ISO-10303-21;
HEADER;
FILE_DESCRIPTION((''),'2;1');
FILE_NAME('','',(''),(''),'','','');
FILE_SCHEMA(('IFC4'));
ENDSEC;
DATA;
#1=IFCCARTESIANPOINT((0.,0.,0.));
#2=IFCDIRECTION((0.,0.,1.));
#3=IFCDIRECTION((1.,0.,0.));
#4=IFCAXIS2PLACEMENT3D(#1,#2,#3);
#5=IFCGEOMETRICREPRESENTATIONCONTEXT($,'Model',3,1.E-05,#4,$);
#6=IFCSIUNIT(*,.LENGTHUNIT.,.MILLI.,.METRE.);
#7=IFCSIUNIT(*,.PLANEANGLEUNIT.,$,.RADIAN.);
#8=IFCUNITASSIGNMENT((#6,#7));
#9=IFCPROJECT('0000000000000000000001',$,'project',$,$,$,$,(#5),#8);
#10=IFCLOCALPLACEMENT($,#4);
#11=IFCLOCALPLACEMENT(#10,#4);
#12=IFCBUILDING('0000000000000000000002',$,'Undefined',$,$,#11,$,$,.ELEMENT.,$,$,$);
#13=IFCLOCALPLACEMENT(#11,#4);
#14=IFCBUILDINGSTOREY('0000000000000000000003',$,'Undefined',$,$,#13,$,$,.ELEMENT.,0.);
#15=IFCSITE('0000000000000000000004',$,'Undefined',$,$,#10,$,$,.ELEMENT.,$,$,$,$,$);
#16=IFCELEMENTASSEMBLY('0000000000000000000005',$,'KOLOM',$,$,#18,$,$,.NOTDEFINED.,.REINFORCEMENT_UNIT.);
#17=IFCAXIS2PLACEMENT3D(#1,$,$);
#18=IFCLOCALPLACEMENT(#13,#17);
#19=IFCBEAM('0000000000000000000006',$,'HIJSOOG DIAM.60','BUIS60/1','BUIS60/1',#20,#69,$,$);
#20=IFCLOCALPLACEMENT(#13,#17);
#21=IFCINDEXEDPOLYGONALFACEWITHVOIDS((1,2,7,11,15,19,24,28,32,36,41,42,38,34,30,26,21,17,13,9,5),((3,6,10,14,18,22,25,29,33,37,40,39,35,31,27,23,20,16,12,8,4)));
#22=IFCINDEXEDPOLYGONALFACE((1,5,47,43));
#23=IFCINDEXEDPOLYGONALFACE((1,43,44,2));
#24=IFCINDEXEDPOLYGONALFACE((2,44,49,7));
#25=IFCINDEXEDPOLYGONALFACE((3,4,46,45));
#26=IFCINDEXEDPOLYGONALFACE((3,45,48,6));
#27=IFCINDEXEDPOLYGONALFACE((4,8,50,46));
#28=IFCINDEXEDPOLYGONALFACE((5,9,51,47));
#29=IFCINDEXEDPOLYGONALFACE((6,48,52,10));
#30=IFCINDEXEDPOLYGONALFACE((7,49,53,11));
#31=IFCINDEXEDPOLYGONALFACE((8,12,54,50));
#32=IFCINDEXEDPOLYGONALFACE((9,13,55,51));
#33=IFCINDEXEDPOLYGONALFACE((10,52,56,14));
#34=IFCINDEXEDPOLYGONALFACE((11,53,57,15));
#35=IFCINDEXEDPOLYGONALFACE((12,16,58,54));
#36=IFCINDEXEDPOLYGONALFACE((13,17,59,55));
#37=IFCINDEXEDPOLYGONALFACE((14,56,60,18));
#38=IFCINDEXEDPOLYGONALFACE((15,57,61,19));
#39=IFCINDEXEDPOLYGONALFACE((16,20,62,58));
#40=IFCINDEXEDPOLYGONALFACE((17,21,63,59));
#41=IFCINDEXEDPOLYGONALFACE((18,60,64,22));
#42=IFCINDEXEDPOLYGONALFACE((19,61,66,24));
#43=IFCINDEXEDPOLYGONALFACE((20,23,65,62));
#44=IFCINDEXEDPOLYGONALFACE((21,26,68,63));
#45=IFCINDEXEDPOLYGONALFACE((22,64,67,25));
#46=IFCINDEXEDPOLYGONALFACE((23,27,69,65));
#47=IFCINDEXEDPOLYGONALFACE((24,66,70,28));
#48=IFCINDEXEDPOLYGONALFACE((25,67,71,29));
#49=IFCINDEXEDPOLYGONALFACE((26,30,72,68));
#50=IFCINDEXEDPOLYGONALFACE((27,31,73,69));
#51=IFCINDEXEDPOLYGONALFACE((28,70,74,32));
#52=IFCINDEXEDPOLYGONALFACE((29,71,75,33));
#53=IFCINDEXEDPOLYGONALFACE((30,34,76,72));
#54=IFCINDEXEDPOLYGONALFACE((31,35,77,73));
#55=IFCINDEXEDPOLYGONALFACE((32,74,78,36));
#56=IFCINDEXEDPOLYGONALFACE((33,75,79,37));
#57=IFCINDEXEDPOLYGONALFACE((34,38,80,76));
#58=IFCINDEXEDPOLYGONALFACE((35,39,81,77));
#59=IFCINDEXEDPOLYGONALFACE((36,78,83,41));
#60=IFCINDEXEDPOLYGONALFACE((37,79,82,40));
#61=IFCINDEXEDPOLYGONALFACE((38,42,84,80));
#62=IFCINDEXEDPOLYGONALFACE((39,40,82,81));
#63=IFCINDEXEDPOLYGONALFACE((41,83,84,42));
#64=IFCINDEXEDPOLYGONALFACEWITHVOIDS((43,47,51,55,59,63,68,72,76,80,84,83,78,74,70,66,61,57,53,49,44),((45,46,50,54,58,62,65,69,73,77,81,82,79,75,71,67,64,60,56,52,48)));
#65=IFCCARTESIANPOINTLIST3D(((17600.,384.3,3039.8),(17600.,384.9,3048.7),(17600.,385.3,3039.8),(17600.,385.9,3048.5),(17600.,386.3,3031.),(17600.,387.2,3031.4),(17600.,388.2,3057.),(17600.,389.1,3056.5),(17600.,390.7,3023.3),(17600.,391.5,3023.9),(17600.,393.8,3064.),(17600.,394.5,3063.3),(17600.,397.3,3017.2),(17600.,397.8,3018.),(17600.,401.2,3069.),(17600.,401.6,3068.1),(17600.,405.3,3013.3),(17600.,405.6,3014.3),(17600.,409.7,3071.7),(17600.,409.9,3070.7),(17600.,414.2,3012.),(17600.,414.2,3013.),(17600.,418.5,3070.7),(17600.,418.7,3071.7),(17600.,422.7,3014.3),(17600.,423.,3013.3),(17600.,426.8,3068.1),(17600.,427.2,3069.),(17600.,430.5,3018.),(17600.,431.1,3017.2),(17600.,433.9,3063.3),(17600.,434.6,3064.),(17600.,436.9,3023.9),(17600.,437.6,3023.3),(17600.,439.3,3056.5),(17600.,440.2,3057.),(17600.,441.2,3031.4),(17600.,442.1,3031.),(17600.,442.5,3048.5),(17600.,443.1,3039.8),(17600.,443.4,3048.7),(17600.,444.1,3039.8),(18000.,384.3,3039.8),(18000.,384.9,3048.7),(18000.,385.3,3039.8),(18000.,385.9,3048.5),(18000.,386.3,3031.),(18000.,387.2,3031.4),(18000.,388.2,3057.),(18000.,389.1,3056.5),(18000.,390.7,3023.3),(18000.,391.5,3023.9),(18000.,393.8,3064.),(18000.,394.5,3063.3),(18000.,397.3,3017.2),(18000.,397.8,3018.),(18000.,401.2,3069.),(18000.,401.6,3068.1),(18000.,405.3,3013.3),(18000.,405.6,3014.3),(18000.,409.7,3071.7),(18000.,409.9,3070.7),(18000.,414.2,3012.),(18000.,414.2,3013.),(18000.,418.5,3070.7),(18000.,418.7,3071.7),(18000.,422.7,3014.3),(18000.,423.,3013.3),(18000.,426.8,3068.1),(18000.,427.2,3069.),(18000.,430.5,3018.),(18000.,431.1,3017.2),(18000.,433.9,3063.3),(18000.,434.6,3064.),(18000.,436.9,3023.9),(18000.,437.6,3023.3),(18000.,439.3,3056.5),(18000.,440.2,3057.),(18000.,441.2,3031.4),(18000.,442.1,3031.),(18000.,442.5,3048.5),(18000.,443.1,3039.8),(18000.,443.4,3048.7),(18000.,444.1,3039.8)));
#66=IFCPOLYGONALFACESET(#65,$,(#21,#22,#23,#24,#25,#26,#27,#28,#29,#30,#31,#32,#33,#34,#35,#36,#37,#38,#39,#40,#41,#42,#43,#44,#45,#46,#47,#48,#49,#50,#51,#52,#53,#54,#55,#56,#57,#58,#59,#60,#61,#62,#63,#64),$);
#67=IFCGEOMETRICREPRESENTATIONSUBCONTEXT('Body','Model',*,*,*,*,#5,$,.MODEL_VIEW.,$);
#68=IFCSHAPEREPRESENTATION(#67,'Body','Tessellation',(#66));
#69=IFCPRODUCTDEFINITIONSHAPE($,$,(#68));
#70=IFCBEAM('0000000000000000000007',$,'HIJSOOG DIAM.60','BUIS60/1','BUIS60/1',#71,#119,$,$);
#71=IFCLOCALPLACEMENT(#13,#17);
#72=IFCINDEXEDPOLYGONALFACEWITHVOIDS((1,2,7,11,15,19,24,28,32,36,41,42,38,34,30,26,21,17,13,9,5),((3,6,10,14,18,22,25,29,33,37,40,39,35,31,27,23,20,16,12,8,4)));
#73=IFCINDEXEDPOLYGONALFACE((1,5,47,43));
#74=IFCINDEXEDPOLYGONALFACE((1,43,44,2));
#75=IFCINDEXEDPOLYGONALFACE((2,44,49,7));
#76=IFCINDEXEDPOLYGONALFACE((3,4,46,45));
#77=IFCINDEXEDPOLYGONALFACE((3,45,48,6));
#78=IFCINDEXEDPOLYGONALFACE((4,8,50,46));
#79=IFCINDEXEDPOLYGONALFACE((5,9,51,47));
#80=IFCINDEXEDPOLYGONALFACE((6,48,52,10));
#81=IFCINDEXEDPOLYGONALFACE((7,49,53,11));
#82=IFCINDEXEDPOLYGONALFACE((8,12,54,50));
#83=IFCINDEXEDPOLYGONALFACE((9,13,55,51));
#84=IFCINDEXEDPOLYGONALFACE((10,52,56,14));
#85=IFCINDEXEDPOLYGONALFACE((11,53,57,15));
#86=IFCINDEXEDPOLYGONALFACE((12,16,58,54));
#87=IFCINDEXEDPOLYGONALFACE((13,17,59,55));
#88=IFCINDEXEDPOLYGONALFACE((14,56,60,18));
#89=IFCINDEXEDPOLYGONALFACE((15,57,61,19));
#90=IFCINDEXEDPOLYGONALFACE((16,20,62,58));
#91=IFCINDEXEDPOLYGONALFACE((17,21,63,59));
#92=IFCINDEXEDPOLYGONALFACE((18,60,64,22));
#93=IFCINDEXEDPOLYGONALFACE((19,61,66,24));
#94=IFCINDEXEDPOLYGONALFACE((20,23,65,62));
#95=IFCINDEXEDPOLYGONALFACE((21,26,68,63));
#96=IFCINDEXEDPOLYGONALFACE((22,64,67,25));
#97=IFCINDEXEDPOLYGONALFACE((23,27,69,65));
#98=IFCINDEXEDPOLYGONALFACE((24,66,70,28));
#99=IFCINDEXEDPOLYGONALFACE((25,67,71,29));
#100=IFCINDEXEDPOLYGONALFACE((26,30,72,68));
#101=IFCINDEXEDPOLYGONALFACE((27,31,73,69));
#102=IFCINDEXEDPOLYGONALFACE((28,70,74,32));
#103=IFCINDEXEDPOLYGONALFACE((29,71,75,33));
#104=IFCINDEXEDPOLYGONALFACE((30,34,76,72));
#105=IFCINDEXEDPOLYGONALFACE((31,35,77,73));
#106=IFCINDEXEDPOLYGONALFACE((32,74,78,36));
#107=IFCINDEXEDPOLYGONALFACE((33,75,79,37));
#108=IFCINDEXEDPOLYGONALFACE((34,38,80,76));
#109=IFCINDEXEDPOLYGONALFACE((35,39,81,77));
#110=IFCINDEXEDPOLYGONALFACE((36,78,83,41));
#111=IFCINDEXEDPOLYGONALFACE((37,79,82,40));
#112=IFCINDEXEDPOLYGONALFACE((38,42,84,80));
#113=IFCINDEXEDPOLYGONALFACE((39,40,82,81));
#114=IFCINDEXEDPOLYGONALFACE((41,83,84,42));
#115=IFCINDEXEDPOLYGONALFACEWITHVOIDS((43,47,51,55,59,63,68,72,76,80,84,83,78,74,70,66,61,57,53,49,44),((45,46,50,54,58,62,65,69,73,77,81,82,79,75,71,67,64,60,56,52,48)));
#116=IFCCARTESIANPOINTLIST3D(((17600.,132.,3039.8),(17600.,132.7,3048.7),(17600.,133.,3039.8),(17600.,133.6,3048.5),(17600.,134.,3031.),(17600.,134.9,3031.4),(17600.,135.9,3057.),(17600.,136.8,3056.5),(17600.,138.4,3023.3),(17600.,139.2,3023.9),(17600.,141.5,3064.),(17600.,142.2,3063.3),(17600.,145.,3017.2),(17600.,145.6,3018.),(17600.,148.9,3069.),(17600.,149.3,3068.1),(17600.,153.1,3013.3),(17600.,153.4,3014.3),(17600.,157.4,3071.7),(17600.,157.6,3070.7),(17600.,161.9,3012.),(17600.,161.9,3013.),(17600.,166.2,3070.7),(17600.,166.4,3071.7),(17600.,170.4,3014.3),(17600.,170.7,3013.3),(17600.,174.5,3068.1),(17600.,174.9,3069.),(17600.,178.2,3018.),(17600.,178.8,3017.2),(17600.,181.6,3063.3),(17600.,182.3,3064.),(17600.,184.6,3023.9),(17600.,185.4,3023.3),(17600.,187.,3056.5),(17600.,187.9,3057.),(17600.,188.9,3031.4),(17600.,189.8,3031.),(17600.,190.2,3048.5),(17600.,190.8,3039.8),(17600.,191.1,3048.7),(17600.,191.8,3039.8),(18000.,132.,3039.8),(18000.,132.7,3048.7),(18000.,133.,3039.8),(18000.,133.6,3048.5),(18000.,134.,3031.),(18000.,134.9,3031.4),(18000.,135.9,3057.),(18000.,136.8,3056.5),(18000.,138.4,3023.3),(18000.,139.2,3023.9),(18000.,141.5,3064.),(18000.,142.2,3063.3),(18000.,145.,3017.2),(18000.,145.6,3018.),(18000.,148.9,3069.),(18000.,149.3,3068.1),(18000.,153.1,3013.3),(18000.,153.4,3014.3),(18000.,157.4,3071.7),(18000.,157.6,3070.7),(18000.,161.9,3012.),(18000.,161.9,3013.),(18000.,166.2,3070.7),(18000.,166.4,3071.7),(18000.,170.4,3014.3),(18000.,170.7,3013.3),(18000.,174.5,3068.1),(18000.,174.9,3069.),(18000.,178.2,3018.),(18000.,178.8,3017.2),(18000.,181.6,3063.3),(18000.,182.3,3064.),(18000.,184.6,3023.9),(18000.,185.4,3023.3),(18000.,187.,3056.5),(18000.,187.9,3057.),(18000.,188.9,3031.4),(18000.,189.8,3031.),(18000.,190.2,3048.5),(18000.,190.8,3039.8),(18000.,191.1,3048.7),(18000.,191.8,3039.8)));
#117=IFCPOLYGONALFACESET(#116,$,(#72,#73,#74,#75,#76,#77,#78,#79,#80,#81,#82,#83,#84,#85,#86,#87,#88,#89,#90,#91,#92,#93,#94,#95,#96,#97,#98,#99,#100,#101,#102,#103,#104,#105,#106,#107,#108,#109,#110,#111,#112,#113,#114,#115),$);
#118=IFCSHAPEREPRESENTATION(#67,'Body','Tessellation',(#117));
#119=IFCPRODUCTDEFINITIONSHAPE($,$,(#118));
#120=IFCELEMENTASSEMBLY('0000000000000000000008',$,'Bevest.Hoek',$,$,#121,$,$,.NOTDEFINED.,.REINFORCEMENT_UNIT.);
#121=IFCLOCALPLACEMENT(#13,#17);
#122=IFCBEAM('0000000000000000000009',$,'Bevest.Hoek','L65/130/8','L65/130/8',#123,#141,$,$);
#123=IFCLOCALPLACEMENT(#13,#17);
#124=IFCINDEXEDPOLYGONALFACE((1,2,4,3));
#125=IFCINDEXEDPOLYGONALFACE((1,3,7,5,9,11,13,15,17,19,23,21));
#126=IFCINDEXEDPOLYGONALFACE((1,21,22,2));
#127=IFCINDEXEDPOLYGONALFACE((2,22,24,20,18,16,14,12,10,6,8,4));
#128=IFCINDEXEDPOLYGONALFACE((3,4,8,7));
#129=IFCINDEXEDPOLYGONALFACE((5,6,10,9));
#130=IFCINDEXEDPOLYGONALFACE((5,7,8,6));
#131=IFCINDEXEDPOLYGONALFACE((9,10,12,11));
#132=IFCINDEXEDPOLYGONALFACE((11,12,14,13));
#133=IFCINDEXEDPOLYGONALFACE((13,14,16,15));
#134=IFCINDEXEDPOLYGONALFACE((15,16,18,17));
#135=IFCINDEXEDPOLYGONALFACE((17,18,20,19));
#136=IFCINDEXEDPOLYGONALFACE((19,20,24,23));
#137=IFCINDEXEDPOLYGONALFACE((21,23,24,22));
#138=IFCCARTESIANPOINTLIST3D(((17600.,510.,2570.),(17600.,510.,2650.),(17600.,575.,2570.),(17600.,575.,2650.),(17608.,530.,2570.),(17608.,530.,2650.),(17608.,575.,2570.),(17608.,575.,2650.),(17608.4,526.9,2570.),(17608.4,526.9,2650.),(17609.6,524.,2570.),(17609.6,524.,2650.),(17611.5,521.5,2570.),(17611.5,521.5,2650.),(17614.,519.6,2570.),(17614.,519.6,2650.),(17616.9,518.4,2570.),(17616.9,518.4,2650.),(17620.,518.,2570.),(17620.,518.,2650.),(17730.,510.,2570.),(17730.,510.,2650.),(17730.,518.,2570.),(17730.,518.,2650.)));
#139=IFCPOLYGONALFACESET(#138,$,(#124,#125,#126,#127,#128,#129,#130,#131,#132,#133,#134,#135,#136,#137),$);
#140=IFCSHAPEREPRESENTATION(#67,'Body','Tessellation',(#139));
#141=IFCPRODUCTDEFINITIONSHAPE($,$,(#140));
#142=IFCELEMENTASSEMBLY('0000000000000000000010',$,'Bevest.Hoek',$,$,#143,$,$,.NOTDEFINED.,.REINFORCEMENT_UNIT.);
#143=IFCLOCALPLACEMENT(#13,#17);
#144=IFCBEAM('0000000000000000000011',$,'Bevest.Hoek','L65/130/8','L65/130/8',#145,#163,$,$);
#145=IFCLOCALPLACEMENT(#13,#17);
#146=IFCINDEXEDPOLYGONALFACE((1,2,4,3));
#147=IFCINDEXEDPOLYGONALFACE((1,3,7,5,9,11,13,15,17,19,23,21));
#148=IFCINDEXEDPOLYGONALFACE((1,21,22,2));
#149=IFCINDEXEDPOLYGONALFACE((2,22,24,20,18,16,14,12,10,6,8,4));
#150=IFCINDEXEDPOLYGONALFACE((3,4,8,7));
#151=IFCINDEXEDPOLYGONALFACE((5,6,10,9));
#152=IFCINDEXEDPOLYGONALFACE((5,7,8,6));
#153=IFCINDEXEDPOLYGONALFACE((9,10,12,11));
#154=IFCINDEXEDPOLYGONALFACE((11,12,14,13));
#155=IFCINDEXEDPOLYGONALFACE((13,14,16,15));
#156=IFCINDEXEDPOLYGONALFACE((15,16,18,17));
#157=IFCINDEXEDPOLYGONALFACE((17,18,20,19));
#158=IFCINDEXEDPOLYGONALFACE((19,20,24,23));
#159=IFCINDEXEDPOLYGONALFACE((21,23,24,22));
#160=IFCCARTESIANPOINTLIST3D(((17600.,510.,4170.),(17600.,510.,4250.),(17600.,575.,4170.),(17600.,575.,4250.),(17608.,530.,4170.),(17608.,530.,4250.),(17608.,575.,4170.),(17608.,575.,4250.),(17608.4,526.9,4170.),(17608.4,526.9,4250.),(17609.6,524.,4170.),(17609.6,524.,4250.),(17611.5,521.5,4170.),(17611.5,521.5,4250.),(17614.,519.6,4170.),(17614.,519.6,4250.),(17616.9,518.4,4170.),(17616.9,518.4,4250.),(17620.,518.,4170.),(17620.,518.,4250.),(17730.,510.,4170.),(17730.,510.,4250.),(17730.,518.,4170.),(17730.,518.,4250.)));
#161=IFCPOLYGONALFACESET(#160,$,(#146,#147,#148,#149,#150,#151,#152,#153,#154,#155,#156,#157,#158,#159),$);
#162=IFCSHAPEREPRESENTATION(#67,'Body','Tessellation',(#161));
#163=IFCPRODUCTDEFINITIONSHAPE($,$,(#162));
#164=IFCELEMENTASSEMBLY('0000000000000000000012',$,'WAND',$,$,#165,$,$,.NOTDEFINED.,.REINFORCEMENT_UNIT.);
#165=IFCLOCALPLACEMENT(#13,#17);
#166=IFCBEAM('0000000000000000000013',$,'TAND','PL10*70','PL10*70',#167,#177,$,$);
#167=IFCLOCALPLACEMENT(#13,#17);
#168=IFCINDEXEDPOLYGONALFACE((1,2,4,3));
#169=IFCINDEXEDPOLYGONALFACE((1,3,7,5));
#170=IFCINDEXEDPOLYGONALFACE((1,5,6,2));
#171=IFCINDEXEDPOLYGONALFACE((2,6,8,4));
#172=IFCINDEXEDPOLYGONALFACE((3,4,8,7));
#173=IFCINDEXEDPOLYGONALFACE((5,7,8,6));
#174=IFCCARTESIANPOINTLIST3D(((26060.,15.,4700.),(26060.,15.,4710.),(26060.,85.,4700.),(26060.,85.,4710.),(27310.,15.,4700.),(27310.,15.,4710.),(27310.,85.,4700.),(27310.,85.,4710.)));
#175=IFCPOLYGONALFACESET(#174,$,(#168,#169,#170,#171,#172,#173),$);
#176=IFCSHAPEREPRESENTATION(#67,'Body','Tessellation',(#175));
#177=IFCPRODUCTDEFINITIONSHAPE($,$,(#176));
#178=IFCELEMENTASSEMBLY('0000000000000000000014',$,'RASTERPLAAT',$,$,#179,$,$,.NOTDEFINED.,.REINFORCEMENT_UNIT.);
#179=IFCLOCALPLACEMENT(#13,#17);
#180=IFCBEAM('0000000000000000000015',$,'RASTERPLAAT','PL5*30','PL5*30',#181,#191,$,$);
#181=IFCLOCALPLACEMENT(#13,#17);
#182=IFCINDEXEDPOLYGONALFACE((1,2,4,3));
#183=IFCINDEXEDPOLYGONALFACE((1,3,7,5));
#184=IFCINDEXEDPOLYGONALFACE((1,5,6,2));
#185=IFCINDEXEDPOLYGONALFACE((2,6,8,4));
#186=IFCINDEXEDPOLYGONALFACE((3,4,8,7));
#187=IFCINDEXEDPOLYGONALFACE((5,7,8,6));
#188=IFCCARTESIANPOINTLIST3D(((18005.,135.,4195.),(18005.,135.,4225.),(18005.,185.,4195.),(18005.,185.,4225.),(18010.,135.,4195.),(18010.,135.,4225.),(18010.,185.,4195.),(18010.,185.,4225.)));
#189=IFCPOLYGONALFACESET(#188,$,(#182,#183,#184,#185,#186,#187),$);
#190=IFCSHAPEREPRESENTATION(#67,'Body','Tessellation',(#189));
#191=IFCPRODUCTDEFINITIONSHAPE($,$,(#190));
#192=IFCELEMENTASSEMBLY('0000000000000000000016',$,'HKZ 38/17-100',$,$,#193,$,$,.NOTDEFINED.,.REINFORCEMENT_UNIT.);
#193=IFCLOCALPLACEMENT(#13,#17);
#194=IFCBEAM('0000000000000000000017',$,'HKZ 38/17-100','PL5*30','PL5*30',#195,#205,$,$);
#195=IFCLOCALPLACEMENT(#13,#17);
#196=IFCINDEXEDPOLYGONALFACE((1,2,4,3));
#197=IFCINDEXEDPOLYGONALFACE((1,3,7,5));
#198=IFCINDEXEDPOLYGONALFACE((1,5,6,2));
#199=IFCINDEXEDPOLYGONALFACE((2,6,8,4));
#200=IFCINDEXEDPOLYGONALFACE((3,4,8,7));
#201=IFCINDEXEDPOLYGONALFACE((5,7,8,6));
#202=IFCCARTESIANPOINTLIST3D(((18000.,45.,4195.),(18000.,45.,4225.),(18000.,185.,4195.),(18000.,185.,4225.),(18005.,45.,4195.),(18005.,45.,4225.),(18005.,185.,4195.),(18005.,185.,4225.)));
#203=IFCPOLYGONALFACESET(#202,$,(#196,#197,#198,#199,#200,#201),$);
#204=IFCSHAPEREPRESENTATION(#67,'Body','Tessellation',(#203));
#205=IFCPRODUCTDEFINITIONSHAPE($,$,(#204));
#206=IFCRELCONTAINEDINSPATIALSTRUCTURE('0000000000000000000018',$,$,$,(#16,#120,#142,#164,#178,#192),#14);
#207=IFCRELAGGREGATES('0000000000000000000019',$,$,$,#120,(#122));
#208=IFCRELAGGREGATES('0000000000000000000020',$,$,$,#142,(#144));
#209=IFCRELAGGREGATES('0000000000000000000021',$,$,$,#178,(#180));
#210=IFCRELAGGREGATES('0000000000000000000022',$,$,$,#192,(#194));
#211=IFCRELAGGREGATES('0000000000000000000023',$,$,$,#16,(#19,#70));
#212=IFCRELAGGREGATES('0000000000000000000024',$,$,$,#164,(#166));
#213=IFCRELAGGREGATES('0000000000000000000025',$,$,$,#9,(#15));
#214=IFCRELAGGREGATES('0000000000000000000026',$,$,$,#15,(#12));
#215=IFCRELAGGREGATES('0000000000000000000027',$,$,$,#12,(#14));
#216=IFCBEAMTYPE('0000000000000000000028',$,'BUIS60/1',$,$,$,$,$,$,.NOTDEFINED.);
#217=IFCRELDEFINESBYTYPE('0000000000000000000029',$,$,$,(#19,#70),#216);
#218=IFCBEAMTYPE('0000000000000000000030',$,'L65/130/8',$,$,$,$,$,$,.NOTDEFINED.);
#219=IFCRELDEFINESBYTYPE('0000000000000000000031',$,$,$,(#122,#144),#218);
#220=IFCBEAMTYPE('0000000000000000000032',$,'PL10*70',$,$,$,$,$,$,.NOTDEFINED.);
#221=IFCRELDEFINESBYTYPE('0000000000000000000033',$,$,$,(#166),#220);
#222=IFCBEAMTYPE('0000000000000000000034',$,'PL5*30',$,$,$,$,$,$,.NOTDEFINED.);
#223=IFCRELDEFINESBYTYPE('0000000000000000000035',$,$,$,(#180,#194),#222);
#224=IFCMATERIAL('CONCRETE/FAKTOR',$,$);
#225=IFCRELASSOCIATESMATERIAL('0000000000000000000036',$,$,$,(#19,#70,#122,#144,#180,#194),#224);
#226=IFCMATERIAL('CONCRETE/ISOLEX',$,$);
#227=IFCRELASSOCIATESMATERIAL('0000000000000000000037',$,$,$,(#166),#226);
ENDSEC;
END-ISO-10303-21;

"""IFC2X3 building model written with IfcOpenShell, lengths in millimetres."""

from ifc_helpers import new_model, si_unit, frame, frame_2d, origin_with_axes, place, context, subcontext, project, spatial, rectangle, hollow_circle, l_section, extrude, material, type_object, element, aggregate, save


model = new_model("IFC2X3")

# Units and contexts
model_context = context("Model", 3, precision=1e-05, world=origin_with_axes())
body_context = subcontext(model_context, "Body", "Model", "MODEL_VIEW")
ifc_project = project(units=[si_unit("LENGTHUNIT", "METRE", prefix="MILLI"), si_unit("PLANEANGLEUNIT", "RADIAN")], contexts=[model_context])

# Site, building, storey
site_placement = place(None, origin_with_axes())
site = spatial("IfcSite", under=ifc_project, at=site_placement, Name="Undefined", CompositionType="ELEMENT")
building_placement = place(site_placement, origin_with_axes())
building = spatial("IfcBuilding", under=site, at=building_placement, Name="Undefined", CompositionType="ELEMENT")
storey_placement = place(building_placement, origin_with_axes())
storey = spatial("IfcBuildingStorey", under=building, at=storey_placement, Name="Undefined", CompositionType="ELEMENT", Elevation=0.0)

# Element assembly, beams
assembly_1_placement = place(storey_placement, origin_with_axes())
assembly_1 = element("IfcElementAssembly", 1, at=assembly_1_placement, inside=storey, Name="KOLOM", AssemblyPlace="NOTDEFINED", PredefinedType="REINFORCEMENT_UNIT")
ifc_material_1 = material(Name="CONCRETE/FAKTOR")
beam_type_1 = type_object("IfcBeamType", Name="BUIS60/1", PredefinedType="NOTDEFINED")
beam_1_placement = place(assembly_1_placement, frame((18000.0, 414.2, 3042.0), z_axis=(0.0, 1.0, 0.0), x_axis=(-1.0, 0.0, 0.0)))
beam_1 = element("IfcBeam", 2, at=beam_1_placement, type_object=beam_type_1, material=ifc_material_1, Name="HIJSOOG DIAM.60", Description="BUIS60/1", ObjectType="BUIS60/1", context=body_context, shape_type="SweptSolid", body=[
    extrude(hollow_circle(Radius=30.0, WallThickness=1.0, at=frame_2d((0.0, 0.0), x_axis=(1.0, 0.0))), frame((400.0, 0.0, 0.0), z_axis=(-1.0, 0.0, 0.0), x_axis=(0.0, -1.0, 0.0)), (0.0, 0.0, 1.0), 400.0),
])
beam_2_placement = place(assembly_1_placement, frame((18000.0, 161.9, 3042.0), z_axis=(0.0, 1.0, 0.0), x_axis=(-1.0, 0.0, 0.0)))
beam_2 = element("IfcBeam", 3, at=beam_2_placement, type_object=beam_type_1, material=ifc_material_1, Name="HIJSOOG DIAM.60", Description="BUIS60/1", ObjectType="BUIS60/1", context=body_context, shape_type="SweptSolid", body=[
    extrude(hollow_circle(Radius=30.0, WallThickness=1.0, at=frame_2d((0.0, 0.0), x_axis=(1.0, 0.0))), frame((400.0, 0.0, 0.0), z_axis=(-1.0, 0.0, 0.0), x_axis=(0.0, -1.0, 0.0)), (0.0, 0.0, 1.0), 400.0),
])

# Element assemblies, beams
assembly_2_placement = place(storey_placement, origin_with_axes())
assembly_2 = element("IfcElementAssembly", 4, at=assembly_2_placement, inside=storey, Name="Bevest.Hoek", AssemblyPlace="NOTDEFINED", PredefinedType="REINFORCEMENT_UNIT")
beam_type_2 = type_object("IfcBeamType", Name="L65/130/8", PredefinedType="NOTDEFINED")
beam_3_placement = place(assembly_2_placement, frame((17665.0, 542.5, 2650.0), z_axis=(0.0, 1.0, 0.0), x_axis=(0.0, 0.0, -1.0)))
beam_3 = element("IfcBeam", 5, at=beam_3_placement, type_object=beam_type_2, material=ifc_material_1, Name="Bevest.Hoek", Description="L65/130/8", ObjectType="L65/130/8", context=body_context, shape_type="SweptSolid", body=[
    extrude(l_section(Depth=65.0, Width=130.0, Thickness=8.0, FilletRadius=12.0, at=frame_2d((0.0, 0.0), x_axis=(1.0, 0.0))), frame((80.0, 0.0, 0.0), z_axis=(-1.0, 0.0, 0.0), x_axis=(0.0, -1.0, 0.0)), (0.0, 0.0, 1.0), 80.0),
])
aggregate(assembly_2, [beam_3])
assembly_3_placement = place(storey_placement, origin_with_axes())
assembly_3 = element("IfcElementAssembly", 6, at=assembly_3_placement, inside=storey, Name="Bevest.Hoek", AssemblyPlace="NOTDEFINED", PredefinedType="REINFORCEMENT_UNIT")
beam_4_placement = place(assembly_3_placement, frame((17665.0, 542.5, 4250.0), z_axis=(0.0, 1.0, 0.0), x_axis=(0.0, 0.0, -1.0)))
beam_4 = element("IfcBeam", 7, at=beam_4_placement, type_object=beam_type_2, material=ifc_material_1, Name="Bevest.Hoek", Description="L65/130/8", ObjectType="L65/130/8", context=body_context, shape_type="SweptSolid", body=[
    extrude(l_section(Depth=65.0, Width=130.0, Thickness=8.0, FilletRadius=12.0, at=frame_2d((0.0, 0.0), x_axis=(1.0, 0.0))), frame((80.0, 0.0, 0.0), z_axis=(-1.0, 0.0, 0.0), x_axis=(0.0, -1.0, 0.0)), (0.0, 0.0, 1.0), 80.0),
])
aggregate(assembly_3, [beam_4])
assembly_4_placement = place(storey_placement, origin_with_axes())
assembly_4 = element("IfcElementAssembly", 8, at=assembly_4_placement, inside=storey, Name="WAND", AssemblyPlace="NOTDEFINED", PredefinedType="REINFORCEMENT_UNIT")
ifc_material_2 = material(Name="CONCRETE/ISOLEX")
beam_type_3 = type_object("IfcBeamType", Name="PL10*70", PredefinedType="NOTDEFINED")
beam_5_placement = place(assembly_4_placement, frame((26060.0, 50.0, 4705.0), z_axis=(0.0, -1.0, 0.0), x_axis=(1.0, 0.0, 0.0)))
beam_5 = element("IfcBeam", 9, at=beam_5_placement, type_object=beam_type_3, material=ifc_material_2, Name="TAND", Description="PL10*70", ObjectType="PL10*70", context=body_context, shape_type="SweptSolid", body=[
    extrude(rectangle(XDim=10.0, YDim=70.0, at=frame_2d((0.0, 0.0), x_axis=(1.0, 0.0))), frame((1250.0, 0.0, 0.0), z_axis=(-1.0, 0.0, 0.0), x_axis=(0.0, -1.0, 0.0)), (0.0, 0.0, 1.0), 1250.0),
])
assembly_5_placement = place(storey_placement, origin_with_axes())
assembly_5 = element("IfcElementAssembly", 10, at=assembly_5_placement, inside=storey, Name="RASTERPLAAT", AssemblyPlace="NOTDEFINED", PredefinedType="REINFORCEMENT_UNIT")
beam_type_4 = type_object("IfcBeamType", Name="PL5*30", PredefinedType="NOTDEFINED")
beam_6_placement = place(assembly_5_placement, frame((18007.5, 185.0, 4210.0), z_axis=(0.0, 0.0, 1.0), x_axis=(0.0, -1.0, 0.0)))
beam_6 = element("IfcBeam", 11, at=beam_6_placement, type_object=beam_type_4, material=ifc_material_1, Name="RASTERPLAAT", Description="PL5*30", ObjectType="PL5*30", context=body_context, shape_type="SweptSolid", body=[
    extrude(rectangle(XDim=5.0, YDim=30.0, at=frame_2d((0.0, 0.0), x_axis=(1.0, 0.0))), frame((50.0, 0.0, 0.0), z_axis=(-1.0, 0.0, 0.0), x_axis=(0.0, -1.0, 0.0)), (0.0, 0.0, 1.0), 50.0),
])
aggregate(assembly_5, [beam_6])
assembly_6_placement = place(storey_placement, origin_with_axes())
assembly_6 = element("IfcElementAssembly", 12, at=assembly_6_placement, inside=storey, Name="HKZ 38/17-100", AssemblyPlace="NOTDEFINED", PredefinedType="REINFORCEMENT_UNIT")
beam_7_placement = place(assembly_6_placement, frame((18002.5, 45.0, 4210.0), z_axis=(0.0, 0.0, 1.0), x_axis=(0.0, 1.0, 0.0)))
beam_7 = element("IfcBeam", 13, at=beam_7_placement, type_object=beam_type_4, material=ifc_material_1, Name="HKZ 38/17-100", Description="PL5*30", ObjectType="PL5*30", context=body_context, shape_type="SweptSolid", body=[
    extrude(rectangle(XDim=5.0, YDim=30.0, at=frame_2d((0.0, 0.0), x_axis=(1.0, 0.0))), frame((140.0, 0.0, 0.0), z_axis=(-1.0, 0.0, 0.0), x_axis=(0.0, -1.0, 0.0)), (0.0, 0.0, 1.0), 140.0),
])
aggregate(assembly_6, [beam_7])

aggregate(assembly_1, [beam_1, beam_2])
aggregate(assembly_4, [beam_5])

save(model, "model.ifc")
